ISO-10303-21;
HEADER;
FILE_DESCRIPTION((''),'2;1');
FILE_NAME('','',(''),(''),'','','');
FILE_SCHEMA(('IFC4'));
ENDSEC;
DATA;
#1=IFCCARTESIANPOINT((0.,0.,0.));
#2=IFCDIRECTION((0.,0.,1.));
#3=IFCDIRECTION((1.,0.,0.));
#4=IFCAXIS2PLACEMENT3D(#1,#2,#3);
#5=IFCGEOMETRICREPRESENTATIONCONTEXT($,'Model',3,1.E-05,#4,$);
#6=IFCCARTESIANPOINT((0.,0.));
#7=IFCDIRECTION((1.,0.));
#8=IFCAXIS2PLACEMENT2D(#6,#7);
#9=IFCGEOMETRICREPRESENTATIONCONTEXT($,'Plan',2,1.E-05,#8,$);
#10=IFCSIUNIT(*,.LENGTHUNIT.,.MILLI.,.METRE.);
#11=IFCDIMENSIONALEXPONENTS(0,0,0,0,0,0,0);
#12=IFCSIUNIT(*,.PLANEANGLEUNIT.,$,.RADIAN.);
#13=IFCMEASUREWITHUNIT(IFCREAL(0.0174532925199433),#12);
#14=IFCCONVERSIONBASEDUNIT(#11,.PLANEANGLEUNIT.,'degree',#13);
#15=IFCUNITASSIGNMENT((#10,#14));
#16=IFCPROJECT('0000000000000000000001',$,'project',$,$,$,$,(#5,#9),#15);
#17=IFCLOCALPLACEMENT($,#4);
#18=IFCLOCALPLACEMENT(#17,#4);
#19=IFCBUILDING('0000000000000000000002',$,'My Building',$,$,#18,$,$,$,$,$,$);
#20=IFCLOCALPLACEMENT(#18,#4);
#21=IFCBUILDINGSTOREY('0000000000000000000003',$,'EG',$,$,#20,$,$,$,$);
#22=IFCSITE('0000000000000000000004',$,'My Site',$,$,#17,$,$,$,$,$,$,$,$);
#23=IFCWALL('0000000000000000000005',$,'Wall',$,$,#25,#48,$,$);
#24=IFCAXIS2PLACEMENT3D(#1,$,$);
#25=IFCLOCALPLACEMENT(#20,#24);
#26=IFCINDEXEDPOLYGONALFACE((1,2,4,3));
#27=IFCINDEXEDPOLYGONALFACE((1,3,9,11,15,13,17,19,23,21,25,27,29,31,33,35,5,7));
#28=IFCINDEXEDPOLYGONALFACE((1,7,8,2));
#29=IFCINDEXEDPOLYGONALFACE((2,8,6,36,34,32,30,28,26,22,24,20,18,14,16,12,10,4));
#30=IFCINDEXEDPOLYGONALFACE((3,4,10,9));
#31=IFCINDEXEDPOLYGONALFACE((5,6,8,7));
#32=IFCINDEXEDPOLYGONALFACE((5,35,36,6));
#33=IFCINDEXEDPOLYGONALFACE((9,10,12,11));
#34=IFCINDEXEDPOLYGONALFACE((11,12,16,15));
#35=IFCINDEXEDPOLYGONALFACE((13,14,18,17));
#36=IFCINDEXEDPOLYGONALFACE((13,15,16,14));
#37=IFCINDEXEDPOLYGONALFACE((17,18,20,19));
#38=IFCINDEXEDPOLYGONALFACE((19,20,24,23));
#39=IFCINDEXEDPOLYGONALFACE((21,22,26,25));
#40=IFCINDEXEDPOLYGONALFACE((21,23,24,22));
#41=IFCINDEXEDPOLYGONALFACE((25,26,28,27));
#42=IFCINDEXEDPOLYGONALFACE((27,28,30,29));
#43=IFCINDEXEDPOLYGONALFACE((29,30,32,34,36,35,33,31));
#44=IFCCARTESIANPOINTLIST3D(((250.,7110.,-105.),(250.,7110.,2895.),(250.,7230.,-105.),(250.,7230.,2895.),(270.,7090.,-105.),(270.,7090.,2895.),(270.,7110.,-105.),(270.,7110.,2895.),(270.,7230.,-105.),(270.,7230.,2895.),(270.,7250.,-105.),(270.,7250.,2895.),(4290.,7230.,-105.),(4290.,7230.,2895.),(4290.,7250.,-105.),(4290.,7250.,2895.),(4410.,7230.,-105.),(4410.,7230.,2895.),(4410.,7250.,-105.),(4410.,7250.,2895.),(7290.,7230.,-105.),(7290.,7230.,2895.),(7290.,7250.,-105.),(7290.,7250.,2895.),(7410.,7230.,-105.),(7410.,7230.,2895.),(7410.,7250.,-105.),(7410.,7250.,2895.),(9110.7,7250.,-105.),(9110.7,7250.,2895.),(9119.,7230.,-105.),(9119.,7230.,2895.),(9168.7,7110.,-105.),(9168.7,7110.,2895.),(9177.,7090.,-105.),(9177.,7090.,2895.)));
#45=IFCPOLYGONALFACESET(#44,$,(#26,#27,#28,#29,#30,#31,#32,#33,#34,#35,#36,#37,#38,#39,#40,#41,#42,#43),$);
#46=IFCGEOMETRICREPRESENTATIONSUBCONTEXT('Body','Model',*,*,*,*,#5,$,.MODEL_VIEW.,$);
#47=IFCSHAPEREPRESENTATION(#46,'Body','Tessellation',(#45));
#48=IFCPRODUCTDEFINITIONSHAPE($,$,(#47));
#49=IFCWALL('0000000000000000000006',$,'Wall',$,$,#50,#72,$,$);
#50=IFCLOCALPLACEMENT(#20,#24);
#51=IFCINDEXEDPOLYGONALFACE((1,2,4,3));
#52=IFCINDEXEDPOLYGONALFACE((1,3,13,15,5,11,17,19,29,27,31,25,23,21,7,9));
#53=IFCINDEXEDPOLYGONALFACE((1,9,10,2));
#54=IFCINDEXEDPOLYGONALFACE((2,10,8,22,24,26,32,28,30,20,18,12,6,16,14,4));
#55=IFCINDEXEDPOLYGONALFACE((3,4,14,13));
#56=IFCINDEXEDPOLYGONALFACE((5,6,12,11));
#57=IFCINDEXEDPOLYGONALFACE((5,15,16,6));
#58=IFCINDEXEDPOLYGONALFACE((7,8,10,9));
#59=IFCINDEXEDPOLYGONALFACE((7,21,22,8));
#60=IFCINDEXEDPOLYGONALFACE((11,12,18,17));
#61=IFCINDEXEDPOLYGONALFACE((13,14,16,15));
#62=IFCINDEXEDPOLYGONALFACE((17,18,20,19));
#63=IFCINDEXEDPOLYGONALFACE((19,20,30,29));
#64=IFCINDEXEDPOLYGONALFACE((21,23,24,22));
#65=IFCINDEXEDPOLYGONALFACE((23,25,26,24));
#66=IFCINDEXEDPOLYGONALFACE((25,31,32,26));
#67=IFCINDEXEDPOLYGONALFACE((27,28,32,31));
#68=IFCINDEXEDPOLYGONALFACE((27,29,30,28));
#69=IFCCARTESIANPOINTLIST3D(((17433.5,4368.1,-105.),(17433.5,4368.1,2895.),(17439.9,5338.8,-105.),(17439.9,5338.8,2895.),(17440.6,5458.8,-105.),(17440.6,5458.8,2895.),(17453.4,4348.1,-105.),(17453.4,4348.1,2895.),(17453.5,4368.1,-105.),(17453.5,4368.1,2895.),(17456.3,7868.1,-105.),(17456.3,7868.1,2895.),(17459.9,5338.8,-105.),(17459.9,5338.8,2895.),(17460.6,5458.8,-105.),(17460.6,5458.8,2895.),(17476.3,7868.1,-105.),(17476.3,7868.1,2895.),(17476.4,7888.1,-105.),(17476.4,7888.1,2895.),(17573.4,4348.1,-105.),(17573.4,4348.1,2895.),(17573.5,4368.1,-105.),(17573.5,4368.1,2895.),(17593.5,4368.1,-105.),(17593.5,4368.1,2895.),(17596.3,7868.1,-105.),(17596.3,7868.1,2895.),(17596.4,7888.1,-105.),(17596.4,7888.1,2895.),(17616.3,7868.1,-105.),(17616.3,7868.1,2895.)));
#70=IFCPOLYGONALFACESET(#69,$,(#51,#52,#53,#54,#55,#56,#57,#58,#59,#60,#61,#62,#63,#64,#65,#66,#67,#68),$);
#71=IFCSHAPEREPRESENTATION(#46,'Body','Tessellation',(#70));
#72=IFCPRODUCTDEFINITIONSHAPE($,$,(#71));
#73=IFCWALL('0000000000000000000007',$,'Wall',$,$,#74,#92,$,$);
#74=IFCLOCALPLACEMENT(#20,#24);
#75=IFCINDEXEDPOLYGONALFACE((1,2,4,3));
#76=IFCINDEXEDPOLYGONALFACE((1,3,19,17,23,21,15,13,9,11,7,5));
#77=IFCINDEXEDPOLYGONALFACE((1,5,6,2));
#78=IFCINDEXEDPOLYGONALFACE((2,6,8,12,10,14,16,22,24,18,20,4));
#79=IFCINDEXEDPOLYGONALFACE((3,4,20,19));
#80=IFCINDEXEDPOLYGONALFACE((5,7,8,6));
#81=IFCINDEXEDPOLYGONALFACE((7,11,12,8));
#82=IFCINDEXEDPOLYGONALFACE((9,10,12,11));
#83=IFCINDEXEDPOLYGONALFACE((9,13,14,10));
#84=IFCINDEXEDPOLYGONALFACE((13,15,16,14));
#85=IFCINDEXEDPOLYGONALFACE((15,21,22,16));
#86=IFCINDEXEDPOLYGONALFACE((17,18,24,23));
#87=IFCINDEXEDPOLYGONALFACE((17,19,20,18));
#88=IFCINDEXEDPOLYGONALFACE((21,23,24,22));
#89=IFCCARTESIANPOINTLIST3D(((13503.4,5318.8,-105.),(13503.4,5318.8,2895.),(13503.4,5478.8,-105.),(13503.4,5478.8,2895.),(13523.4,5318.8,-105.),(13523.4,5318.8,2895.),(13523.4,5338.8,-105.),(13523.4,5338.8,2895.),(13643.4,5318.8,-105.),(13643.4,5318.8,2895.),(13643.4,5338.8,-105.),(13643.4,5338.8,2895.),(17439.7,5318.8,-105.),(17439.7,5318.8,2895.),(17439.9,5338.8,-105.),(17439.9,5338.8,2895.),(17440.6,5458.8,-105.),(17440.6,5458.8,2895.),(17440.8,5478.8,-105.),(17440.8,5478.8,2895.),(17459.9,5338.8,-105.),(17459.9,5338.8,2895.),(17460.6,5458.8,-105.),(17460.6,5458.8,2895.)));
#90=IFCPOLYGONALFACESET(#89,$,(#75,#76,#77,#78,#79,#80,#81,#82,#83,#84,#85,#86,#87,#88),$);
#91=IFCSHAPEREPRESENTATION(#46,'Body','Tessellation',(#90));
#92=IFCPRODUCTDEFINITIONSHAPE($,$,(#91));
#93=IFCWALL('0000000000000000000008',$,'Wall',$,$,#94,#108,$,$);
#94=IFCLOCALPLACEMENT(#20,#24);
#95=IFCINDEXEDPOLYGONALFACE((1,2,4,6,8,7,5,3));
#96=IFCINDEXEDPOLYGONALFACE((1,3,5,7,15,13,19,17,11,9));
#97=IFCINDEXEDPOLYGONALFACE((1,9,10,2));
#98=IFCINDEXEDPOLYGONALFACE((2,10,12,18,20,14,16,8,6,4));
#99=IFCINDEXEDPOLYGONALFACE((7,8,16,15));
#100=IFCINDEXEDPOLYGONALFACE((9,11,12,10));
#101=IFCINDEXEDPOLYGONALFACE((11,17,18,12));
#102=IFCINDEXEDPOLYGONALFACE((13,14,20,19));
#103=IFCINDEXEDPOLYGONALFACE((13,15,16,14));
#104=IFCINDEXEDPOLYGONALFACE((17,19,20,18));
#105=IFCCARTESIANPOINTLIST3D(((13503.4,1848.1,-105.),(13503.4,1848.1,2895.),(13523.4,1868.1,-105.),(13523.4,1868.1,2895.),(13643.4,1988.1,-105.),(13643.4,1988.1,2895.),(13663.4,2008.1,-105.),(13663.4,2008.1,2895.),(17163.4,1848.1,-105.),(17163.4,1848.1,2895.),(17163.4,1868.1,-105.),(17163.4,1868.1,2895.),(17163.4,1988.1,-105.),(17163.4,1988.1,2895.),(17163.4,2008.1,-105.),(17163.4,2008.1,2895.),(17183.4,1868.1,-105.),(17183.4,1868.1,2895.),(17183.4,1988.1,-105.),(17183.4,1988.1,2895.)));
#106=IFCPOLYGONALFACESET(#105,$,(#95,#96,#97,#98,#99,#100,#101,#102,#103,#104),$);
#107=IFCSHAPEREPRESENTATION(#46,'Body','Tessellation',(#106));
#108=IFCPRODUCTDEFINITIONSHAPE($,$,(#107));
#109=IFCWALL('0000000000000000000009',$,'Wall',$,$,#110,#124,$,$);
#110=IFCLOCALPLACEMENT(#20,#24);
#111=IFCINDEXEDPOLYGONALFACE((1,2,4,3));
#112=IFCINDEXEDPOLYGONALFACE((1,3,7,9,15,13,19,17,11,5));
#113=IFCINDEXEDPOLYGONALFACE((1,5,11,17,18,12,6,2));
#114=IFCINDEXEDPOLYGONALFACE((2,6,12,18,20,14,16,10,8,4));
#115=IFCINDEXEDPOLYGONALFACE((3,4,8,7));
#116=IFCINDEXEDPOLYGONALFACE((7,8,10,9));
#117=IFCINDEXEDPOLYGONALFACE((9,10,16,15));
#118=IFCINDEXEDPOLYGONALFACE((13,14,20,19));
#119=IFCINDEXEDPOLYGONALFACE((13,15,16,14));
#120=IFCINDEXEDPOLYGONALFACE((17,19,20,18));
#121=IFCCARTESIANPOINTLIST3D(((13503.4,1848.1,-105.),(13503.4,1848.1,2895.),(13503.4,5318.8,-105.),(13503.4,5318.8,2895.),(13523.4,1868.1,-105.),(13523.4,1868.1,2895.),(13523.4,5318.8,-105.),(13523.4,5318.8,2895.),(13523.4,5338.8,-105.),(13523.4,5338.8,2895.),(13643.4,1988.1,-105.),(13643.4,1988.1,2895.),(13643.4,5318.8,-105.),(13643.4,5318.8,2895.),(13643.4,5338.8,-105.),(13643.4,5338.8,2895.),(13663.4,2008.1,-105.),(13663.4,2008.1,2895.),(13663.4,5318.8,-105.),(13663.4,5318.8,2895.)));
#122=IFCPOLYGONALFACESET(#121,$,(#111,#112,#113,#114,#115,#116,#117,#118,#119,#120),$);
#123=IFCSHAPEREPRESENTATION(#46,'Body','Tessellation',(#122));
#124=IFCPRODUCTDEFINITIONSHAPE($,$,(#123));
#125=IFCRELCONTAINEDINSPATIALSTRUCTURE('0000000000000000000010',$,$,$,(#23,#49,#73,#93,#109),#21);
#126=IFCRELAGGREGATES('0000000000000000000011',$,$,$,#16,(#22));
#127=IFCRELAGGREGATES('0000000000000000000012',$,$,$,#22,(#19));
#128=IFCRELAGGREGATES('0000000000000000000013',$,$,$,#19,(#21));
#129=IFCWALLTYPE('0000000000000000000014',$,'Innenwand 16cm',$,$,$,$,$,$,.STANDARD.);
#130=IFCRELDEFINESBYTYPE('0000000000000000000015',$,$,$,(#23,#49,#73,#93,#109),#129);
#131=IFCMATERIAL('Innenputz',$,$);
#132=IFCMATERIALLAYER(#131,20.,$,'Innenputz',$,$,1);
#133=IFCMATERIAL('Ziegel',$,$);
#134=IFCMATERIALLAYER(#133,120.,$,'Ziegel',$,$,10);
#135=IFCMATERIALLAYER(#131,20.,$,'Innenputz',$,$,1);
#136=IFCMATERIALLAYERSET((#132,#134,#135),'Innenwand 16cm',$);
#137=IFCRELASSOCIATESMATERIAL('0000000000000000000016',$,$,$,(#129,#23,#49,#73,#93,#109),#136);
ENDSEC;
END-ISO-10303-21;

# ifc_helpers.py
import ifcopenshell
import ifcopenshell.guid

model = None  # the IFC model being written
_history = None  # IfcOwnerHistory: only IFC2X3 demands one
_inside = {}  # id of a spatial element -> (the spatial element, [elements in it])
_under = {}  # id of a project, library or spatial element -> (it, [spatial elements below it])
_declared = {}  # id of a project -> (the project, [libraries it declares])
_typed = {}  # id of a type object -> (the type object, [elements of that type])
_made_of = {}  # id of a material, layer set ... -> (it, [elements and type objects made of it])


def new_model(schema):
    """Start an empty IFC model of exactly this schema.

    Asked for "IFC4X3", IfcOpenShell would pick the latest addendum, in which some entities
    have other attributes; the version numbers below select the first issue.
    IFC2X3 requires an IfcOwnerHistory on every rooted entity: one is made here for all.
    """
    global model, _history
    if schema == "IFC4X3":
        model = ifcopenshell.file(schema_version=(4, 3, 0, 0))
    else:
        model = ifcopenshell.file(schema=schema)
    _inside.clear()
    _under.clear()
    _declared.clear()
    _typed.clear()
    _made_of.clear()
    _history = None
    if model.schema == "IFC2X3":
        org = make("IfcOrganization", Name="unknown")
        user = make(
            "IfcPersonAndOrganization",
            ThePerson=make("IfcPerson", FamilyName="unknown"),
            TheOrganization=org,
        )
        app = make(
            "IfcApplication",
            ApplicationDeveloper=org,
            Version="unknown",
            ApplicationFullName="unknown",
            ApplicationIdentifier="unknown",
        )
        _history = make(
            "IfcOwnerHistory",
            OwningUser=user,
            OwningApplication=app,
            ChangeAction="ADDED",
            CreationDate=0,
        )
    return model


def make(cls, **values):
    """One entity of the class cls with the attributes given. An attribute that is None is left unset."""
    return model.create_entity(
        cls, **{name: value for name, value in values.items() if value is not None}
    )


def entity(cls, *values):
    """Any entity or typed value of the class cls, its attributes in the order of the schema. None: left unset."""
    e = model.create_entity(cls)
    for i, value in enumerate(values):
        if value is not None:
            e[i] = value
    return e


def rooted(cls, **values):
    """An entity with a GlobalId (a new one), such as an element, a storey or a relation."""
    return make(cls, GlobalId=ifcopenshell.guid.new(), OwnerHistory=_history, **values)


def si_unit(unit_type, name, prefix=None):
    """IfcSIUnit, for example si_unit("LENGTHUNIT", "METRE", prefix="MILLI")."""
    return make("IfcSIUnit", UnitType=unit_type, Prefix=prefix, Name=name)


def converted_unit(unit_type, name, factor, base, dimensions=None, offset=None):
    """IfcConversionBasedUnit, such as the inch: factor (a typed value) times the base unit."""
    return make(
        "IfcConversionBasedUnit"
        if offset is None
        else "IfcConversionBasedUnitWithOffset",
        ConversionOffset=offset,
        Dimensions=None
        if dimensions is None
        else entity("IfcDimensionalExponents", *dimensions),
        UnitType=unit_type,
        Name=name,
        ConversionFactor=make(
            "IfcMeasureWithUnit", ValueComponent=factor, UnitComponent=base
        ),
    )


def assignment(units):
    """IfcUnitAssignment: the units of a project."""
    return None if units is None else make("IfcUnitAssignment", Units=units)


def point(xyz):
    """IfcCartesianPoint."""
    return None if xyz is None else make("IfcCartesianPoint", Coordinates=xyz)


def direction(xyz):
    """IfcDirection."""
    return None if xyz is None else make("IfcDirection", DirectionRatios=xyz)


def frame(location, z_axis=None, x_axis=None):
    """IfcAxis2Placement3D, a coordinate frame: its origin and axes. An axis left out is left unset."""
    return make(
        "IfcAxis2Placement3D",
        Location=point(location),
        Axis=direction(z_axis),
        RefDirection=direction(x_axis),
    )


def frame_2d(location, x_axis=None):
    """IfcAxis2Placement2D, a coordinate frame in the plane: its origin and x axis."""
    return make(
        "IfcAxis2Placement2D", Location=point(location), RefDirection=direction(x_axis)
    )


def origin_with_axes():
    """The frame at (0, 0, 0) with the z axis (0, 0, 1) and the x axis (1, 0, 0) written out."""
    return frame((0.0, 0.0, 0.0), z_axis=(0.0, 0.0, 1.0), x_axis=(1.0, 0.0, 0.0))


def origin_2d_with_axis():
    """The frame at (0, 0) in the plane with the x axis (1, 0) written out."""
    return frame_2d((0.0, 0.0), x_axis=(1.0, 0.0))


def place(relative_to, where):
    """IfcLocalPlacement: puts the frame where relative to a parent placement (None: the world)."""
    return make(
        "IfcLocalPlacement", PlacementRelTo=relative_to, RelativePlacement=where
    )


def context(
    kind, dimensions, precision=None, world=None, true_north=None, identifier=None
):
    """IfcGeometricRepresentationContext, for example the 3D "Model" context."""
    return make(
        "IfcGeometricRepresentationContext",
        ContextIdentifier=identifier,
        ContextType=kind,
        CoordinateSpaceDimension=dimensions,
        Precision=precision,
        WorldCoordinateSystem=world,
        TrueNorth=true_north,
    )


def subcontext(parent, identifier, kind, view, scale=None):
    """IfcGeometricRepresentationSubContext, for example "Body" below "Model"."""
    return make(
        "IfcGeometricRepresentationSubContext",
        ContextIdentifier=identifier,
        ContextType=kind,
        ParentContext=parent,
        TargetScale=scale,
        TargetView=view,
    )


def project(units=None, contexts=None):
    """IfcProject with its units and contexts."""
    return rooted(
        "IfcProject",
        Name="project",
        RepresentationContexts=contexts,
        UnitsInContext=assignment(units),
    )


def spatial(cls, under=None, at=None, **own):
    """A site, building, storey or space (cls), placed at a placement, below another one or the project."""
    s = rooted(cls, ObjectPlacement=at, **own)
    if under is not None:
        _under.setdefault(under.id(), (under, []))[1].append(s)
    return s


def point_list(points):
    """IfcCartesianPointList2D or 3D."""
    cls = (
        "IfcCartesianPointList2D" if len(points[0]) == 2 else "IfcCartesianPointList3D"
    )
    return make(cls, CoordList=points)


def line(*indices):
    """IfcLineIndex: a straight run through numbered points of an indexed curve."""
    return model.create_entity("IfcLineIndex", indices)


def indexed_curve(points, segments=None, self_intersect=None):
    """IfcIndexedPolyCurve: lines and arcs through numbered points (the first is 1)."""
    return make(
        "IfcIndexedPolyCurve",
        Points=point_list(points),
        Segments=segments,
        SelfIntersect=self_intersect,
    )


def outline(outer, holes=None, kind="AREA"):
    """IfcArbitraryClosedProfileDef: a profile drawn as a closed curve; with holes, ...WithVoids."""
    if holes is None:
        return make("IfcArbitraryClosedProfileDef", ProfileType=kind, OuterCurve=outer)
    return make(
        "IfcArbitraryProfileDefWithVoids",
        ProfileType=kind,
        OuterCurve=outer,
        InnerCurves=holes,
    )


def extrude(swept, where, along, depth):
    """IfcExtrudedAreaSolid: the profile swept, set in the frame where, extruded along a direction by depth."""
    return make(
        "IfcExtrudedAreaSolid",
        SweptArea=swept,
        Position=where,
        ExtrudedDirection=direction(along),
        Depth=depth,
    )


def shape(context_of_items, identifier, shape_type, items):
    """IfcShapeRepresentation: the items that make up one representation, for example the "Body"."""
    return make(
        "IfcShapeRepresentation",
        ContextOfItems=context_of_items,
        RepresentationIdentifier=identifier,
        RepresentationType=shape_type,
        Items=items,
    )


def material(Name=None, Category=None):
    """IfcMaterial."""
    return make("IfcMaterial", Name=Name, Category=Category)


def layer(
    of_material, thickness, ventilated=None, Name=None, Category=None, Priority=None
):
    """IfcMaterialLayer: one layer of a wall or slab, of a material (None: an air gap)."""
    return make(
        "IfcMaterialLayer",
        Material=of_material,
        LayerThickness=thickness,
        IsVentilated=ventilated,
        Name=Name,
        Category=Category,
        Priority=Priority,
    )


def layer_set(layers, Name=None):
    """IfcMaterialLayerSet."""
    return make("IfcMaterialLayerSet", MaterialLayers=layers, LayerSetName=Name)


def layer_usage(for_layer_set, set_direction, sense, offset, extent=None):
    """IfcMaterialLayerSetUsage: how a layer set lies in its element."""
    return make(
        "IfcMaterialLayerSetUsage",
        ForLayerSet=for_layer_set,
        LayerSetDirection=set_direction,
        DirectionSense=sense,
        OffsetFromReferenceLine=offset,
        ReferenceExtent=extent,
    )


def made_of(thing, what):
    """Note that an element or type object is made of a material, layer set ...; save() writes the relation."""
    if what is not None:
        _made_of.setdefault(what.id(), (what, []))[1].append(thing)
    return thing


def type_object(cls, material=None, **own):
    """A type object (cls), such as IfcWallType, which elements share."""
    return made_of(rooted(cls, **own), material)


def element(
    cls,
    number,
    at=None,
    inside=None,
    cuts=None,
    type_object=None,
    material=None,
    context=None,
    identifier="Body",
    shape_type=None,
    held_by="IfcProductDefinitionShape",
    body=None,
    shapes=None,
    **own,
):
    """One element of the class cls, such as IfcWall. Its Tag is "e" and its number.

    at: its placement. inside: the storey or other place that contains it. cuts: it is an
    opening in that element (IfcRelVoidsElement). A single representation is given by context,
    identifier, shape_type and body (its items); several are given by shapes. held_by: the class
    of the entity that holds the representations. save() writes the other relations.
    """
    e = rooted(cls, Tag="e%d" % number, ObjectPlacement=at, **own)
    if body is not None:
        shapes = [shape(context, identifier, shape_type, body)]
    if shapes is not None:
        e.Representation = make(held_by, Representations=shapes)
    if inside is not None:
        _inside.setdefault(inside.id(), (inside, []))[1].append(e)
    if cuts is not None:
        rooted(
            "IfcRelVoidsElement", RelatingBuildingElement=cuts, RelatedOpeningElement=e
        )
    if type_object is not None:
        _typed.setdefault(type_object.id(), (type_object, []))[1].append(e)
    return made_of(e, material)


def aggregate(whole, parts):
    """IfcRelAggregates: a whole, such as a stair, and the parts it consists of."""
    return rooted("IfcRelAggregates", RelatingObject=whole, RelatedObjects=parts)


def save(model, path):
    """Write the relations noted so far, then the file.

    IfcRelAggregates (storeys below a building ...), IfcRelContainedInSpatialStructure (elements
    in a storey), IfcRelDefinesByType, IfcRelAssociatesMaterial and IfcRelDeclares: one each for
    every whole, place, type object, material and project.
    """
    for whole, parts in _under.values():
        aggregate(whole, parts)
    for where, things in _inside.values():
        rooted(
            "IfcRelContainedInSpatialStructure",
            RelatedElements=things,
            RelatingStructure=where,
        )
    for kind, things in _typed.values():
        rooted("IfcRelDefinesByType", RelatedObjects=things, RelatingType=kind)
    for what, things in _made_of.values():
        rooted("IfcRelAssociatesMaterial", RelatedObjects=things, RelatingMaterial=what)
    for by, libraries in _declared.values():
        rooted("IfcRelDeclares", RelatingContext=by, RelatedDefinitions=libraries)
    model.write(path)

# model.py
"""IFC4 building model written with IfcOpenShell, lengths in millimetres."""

from ifc_helpers import new_model, entity, si_unit, converted_unit, frame, origin_with_axes, origin_2d_with_axis, place, context, subcontext, project, spatial, line, indexed_curve, outline, extrude, material, layer, layer_set, layer_usage, type_object, element, save


model = new_model("IFC4")

# Units and contexts
model_context = context("Model", 3, precision=1e-05, world=origin_with_axes())
plan_context = context("Plan", 2, precision=1e-05, world=origin_2d_with_axis())
body_context = subcontext(model_context, "Body", "Model", "MODEL_VIEW")
ifc_project = project(units=[si_unit("LENGTHUNIT", "METRE", prefix="MILLI"), converted_unit("PLANEANGLEUNIT", "degree", entity("IfcReal", 0.0174532925199433), si_unit("PLANEANGLEUNIT", "RADIAN"), dimensions=[0, 0, 0, 0, 0, 0, 0])], contexts=[model_context, plan_context])

# Site, building, storey
site_placement = place(None, origin_with_axes())
site = spatial("IfcSite", under=ifc_project, at=site_placement, Name="My Site")
building_placement = place(site_placement, origin_with_axes())
building = spatial("IfcBuilding", under=site, at=building_placement, Name="My Building")
storey_placement = place(building_placement, origin_with_axes())
storey = spatial("IfcBuildingStorey", under=building, at=storey_placement, Name="EG")

# Walls
ifc_material_1 = material(Name="Innenputz")
ifc_material_2 = material(Name="Ziegel")
ifc_layer_1 = layer(ifc_material_1, 20.0, Name="Innenputz", Priority=1)
ifc_layer_2 = layer(ifc_material_2, 120.0, Name="Ziegel", Priority=10)
ifc_layer_3 = layer(ifc_material_1, 20.0, Name="Innenputz", Priority=1)
ifc_layer_set_1 = layer_set([ifc_layer_1, ifc_layer_2, ifc_layer_3], Name="Innenwand 16cm")
ifc_layer_usage_1 = layer_usage(ifc_layer_set_1, "AXIS2", "POSITIVE", 0.0)
wall_type_1 = type_object("IfcWallType", Name="Innenwand 16cm", PredefinedType="STANDARD", material=ifc_layer_set_1)
wall_1_placement = place(storey_placement, frame((270.0, 7090.0, -105.0), z_axis=(0.0, 0.0, 1.0), x_axis=(1.0, 0.0, 0.0)))
element("IfcWall", 1, at=wall_1_placement, inside=storey, type_object=wall_type_1, material=ifc_layer_usage_1, Name="Wall", context=body_context, shape_type="SweptSolid", body=[
    extrude(outline(indexed_curve([(0.0, 0.0), (0.0, 20.0), (-20.0, 20.0), (-20.0, 140.0), (0.0, 140.0), (0.0, 160.0), (4020.0, 160.0), (4020.0, 140.0), (4140.0, 140.0), (4140.0, 160.0), (7020.0, 160.0), (7020.0, 140.0), (7140.0, 140.0), (7140.0, 160.0), (8840.7, 160.0), (8849.0, 140.0), (8898.7, 20.0), (8907.0, 0.0)], segments=[line(1, 2, 3, 4, 5, 6, 7, 8, 9, 10, 11, 12, 13, 14, 15, 16, 17, 18, 1)])), origin_with_axes(), (0.0, 0.0, 1.0), 3000.0),
])
ifc_layer_usage_2 = layer_usage(ifc_layer_set_1, "AXIS2", "POSITIVE", 0.0)
wall_2_placement = place(storey_placement, frame((17456.3, 7868.1, -105.0), z_axis=(0.0, 0.0, 1.0), x_axis=(-0.006503, -0.999979, 0.0)))
element("IfcWall", 2, at=wall_2_placement, inside=storey, type_object=wall_type_1, material=ifc_layer_usage_2, Name="Wall", context=body_context, shape_type="SweptSolid", body=[
    extrude(outline(indexed_curve([(0.0, 0.0), (-0.1, 20.0), (-20.1, 20.0), (-20.9, 140.0), (-0.9, 140.0), (-1.0, 160.0), (3499.0, 160.0), (3499.2, 140.0), (3519.2, 140.0), (3519.9, 20.0), (3499.9, 20.0), (3500.1, 0.0), (2529.3, 0.0), (2529.2, 20.0), (2409.2, 20.0), (2409.3, 0.0)], segments=[line(1, 2, 3, 4, 5, 6, 7, 8, 9, 10, 11, 12, 13, 14, 15, 16, 1)])), origin_with_axes(), (0.0, 0.0, 1.0), 3000.0),
])
ifc_layer_usage_3 = layer_usage(ifc_layer_set_1, "AXIS2", "POSITIVE", 0.0)
wall_3_placement = place(storey_placement, frame((13503.4, 5318.8, -105.0), z_axis=(0.0, 0.0, 1.0), x_axis=(1.0, 0.0, 0.0)))
element("IfcWall", 3, at=wall_3_placement, inside=storey, type_object=wall_type_1, material=ifc_layer_usage_3, Name="Wall", context=body_context, shape_type="SweptSolid", body=[
    extrude(outline(indexed_curve([(0.0, 0.0), (0.0, 160.0), (3937.4, 160.0), (3937.2, 140.0), (3957.2, 140.0), (3956.4, 20.0), (3936.4, 20.0), (3936.3, 0.0), (140.0, 0.0), (140.0, 20.0), (20.0, 20.0), (20.0, 0.0)], segments=[line(1, 2, 3, 4, 5, 6, 7, 8, 9, 10, 11, 12, 1)])), origin_with_axes(), (0.0, 0.0, 1.0), 3000.0),
])
ifc_layer_usage_4 = layer_usage(ifc_layer_set_1, "AXIS2", "POSITIVE", 0.0)
wall_4_placement = place(storey_placement, frame((17163.4, 2008.1, -105.0), z_axis=(0.0, 0.0, 1.0), x_axis=(-1.0, 0.0, 0.0)))
element("IfcWall", 4, at=wall_4_placement, inside=storey, type_object=wall_type_1, material=ifc_layer_usage_4, Name="Wall", context=body_context, shape_type="SweptSolid", body=[
    extrude(outline(indexed_curve([(0.0, 0.0), (0.0, 20.0), (-20.0, 20.0), (-20.0, 140.0), (0.0, 140.0), (0.0, 160.0), (3660.0, 160.0), (3640.0, 140.0), (3520.0, 20.0), (3500.0, 0.0)], segments=[line(1, 2, 3, 4, 5, 6, 7, 8, 9, 10, 1)])), origin_with_axes(), (0.0, 0.0, 1.0), 3000.0),
])
ifc_layer_usage_5 = layer_usage(ifc_layer_set_1, "AXIS2", "POSITIVE", 0.0)
wall_5_placement = place(storey_placement, frame((13663.4, 2008.1, -105.0), z_axis=(0.0, 0.0, 1.0), x_axis=(0.0, 1.0, 0.0)))
element("IfcWall", 5, at=wall_5_placement, inside=storey, type_object=wall_type_1, material=ifc_layer_usage_5, Name="Wall", context=body_context, shape_type="SweptSolid", body=[
    extrude(outline(indexed_curve([(0.0, 0.0), (-20.0, 20.0), (-140.0, 140.0), (-160.0, 160.0), (3310.8, 160.0), (3310.8, 140.0), (3330.8, 140.0), (3330.8, 20.0), (3310.8, 20.0), (3310.8, 0.0)], segments=[line(1, 2, 3, 4, 5, 6, 7, 8, 9, 10, 1)])), origin_with_axes(), (0.0, 0.0, 1.0), 3000.0),
])

save(model, "model.ifc")
